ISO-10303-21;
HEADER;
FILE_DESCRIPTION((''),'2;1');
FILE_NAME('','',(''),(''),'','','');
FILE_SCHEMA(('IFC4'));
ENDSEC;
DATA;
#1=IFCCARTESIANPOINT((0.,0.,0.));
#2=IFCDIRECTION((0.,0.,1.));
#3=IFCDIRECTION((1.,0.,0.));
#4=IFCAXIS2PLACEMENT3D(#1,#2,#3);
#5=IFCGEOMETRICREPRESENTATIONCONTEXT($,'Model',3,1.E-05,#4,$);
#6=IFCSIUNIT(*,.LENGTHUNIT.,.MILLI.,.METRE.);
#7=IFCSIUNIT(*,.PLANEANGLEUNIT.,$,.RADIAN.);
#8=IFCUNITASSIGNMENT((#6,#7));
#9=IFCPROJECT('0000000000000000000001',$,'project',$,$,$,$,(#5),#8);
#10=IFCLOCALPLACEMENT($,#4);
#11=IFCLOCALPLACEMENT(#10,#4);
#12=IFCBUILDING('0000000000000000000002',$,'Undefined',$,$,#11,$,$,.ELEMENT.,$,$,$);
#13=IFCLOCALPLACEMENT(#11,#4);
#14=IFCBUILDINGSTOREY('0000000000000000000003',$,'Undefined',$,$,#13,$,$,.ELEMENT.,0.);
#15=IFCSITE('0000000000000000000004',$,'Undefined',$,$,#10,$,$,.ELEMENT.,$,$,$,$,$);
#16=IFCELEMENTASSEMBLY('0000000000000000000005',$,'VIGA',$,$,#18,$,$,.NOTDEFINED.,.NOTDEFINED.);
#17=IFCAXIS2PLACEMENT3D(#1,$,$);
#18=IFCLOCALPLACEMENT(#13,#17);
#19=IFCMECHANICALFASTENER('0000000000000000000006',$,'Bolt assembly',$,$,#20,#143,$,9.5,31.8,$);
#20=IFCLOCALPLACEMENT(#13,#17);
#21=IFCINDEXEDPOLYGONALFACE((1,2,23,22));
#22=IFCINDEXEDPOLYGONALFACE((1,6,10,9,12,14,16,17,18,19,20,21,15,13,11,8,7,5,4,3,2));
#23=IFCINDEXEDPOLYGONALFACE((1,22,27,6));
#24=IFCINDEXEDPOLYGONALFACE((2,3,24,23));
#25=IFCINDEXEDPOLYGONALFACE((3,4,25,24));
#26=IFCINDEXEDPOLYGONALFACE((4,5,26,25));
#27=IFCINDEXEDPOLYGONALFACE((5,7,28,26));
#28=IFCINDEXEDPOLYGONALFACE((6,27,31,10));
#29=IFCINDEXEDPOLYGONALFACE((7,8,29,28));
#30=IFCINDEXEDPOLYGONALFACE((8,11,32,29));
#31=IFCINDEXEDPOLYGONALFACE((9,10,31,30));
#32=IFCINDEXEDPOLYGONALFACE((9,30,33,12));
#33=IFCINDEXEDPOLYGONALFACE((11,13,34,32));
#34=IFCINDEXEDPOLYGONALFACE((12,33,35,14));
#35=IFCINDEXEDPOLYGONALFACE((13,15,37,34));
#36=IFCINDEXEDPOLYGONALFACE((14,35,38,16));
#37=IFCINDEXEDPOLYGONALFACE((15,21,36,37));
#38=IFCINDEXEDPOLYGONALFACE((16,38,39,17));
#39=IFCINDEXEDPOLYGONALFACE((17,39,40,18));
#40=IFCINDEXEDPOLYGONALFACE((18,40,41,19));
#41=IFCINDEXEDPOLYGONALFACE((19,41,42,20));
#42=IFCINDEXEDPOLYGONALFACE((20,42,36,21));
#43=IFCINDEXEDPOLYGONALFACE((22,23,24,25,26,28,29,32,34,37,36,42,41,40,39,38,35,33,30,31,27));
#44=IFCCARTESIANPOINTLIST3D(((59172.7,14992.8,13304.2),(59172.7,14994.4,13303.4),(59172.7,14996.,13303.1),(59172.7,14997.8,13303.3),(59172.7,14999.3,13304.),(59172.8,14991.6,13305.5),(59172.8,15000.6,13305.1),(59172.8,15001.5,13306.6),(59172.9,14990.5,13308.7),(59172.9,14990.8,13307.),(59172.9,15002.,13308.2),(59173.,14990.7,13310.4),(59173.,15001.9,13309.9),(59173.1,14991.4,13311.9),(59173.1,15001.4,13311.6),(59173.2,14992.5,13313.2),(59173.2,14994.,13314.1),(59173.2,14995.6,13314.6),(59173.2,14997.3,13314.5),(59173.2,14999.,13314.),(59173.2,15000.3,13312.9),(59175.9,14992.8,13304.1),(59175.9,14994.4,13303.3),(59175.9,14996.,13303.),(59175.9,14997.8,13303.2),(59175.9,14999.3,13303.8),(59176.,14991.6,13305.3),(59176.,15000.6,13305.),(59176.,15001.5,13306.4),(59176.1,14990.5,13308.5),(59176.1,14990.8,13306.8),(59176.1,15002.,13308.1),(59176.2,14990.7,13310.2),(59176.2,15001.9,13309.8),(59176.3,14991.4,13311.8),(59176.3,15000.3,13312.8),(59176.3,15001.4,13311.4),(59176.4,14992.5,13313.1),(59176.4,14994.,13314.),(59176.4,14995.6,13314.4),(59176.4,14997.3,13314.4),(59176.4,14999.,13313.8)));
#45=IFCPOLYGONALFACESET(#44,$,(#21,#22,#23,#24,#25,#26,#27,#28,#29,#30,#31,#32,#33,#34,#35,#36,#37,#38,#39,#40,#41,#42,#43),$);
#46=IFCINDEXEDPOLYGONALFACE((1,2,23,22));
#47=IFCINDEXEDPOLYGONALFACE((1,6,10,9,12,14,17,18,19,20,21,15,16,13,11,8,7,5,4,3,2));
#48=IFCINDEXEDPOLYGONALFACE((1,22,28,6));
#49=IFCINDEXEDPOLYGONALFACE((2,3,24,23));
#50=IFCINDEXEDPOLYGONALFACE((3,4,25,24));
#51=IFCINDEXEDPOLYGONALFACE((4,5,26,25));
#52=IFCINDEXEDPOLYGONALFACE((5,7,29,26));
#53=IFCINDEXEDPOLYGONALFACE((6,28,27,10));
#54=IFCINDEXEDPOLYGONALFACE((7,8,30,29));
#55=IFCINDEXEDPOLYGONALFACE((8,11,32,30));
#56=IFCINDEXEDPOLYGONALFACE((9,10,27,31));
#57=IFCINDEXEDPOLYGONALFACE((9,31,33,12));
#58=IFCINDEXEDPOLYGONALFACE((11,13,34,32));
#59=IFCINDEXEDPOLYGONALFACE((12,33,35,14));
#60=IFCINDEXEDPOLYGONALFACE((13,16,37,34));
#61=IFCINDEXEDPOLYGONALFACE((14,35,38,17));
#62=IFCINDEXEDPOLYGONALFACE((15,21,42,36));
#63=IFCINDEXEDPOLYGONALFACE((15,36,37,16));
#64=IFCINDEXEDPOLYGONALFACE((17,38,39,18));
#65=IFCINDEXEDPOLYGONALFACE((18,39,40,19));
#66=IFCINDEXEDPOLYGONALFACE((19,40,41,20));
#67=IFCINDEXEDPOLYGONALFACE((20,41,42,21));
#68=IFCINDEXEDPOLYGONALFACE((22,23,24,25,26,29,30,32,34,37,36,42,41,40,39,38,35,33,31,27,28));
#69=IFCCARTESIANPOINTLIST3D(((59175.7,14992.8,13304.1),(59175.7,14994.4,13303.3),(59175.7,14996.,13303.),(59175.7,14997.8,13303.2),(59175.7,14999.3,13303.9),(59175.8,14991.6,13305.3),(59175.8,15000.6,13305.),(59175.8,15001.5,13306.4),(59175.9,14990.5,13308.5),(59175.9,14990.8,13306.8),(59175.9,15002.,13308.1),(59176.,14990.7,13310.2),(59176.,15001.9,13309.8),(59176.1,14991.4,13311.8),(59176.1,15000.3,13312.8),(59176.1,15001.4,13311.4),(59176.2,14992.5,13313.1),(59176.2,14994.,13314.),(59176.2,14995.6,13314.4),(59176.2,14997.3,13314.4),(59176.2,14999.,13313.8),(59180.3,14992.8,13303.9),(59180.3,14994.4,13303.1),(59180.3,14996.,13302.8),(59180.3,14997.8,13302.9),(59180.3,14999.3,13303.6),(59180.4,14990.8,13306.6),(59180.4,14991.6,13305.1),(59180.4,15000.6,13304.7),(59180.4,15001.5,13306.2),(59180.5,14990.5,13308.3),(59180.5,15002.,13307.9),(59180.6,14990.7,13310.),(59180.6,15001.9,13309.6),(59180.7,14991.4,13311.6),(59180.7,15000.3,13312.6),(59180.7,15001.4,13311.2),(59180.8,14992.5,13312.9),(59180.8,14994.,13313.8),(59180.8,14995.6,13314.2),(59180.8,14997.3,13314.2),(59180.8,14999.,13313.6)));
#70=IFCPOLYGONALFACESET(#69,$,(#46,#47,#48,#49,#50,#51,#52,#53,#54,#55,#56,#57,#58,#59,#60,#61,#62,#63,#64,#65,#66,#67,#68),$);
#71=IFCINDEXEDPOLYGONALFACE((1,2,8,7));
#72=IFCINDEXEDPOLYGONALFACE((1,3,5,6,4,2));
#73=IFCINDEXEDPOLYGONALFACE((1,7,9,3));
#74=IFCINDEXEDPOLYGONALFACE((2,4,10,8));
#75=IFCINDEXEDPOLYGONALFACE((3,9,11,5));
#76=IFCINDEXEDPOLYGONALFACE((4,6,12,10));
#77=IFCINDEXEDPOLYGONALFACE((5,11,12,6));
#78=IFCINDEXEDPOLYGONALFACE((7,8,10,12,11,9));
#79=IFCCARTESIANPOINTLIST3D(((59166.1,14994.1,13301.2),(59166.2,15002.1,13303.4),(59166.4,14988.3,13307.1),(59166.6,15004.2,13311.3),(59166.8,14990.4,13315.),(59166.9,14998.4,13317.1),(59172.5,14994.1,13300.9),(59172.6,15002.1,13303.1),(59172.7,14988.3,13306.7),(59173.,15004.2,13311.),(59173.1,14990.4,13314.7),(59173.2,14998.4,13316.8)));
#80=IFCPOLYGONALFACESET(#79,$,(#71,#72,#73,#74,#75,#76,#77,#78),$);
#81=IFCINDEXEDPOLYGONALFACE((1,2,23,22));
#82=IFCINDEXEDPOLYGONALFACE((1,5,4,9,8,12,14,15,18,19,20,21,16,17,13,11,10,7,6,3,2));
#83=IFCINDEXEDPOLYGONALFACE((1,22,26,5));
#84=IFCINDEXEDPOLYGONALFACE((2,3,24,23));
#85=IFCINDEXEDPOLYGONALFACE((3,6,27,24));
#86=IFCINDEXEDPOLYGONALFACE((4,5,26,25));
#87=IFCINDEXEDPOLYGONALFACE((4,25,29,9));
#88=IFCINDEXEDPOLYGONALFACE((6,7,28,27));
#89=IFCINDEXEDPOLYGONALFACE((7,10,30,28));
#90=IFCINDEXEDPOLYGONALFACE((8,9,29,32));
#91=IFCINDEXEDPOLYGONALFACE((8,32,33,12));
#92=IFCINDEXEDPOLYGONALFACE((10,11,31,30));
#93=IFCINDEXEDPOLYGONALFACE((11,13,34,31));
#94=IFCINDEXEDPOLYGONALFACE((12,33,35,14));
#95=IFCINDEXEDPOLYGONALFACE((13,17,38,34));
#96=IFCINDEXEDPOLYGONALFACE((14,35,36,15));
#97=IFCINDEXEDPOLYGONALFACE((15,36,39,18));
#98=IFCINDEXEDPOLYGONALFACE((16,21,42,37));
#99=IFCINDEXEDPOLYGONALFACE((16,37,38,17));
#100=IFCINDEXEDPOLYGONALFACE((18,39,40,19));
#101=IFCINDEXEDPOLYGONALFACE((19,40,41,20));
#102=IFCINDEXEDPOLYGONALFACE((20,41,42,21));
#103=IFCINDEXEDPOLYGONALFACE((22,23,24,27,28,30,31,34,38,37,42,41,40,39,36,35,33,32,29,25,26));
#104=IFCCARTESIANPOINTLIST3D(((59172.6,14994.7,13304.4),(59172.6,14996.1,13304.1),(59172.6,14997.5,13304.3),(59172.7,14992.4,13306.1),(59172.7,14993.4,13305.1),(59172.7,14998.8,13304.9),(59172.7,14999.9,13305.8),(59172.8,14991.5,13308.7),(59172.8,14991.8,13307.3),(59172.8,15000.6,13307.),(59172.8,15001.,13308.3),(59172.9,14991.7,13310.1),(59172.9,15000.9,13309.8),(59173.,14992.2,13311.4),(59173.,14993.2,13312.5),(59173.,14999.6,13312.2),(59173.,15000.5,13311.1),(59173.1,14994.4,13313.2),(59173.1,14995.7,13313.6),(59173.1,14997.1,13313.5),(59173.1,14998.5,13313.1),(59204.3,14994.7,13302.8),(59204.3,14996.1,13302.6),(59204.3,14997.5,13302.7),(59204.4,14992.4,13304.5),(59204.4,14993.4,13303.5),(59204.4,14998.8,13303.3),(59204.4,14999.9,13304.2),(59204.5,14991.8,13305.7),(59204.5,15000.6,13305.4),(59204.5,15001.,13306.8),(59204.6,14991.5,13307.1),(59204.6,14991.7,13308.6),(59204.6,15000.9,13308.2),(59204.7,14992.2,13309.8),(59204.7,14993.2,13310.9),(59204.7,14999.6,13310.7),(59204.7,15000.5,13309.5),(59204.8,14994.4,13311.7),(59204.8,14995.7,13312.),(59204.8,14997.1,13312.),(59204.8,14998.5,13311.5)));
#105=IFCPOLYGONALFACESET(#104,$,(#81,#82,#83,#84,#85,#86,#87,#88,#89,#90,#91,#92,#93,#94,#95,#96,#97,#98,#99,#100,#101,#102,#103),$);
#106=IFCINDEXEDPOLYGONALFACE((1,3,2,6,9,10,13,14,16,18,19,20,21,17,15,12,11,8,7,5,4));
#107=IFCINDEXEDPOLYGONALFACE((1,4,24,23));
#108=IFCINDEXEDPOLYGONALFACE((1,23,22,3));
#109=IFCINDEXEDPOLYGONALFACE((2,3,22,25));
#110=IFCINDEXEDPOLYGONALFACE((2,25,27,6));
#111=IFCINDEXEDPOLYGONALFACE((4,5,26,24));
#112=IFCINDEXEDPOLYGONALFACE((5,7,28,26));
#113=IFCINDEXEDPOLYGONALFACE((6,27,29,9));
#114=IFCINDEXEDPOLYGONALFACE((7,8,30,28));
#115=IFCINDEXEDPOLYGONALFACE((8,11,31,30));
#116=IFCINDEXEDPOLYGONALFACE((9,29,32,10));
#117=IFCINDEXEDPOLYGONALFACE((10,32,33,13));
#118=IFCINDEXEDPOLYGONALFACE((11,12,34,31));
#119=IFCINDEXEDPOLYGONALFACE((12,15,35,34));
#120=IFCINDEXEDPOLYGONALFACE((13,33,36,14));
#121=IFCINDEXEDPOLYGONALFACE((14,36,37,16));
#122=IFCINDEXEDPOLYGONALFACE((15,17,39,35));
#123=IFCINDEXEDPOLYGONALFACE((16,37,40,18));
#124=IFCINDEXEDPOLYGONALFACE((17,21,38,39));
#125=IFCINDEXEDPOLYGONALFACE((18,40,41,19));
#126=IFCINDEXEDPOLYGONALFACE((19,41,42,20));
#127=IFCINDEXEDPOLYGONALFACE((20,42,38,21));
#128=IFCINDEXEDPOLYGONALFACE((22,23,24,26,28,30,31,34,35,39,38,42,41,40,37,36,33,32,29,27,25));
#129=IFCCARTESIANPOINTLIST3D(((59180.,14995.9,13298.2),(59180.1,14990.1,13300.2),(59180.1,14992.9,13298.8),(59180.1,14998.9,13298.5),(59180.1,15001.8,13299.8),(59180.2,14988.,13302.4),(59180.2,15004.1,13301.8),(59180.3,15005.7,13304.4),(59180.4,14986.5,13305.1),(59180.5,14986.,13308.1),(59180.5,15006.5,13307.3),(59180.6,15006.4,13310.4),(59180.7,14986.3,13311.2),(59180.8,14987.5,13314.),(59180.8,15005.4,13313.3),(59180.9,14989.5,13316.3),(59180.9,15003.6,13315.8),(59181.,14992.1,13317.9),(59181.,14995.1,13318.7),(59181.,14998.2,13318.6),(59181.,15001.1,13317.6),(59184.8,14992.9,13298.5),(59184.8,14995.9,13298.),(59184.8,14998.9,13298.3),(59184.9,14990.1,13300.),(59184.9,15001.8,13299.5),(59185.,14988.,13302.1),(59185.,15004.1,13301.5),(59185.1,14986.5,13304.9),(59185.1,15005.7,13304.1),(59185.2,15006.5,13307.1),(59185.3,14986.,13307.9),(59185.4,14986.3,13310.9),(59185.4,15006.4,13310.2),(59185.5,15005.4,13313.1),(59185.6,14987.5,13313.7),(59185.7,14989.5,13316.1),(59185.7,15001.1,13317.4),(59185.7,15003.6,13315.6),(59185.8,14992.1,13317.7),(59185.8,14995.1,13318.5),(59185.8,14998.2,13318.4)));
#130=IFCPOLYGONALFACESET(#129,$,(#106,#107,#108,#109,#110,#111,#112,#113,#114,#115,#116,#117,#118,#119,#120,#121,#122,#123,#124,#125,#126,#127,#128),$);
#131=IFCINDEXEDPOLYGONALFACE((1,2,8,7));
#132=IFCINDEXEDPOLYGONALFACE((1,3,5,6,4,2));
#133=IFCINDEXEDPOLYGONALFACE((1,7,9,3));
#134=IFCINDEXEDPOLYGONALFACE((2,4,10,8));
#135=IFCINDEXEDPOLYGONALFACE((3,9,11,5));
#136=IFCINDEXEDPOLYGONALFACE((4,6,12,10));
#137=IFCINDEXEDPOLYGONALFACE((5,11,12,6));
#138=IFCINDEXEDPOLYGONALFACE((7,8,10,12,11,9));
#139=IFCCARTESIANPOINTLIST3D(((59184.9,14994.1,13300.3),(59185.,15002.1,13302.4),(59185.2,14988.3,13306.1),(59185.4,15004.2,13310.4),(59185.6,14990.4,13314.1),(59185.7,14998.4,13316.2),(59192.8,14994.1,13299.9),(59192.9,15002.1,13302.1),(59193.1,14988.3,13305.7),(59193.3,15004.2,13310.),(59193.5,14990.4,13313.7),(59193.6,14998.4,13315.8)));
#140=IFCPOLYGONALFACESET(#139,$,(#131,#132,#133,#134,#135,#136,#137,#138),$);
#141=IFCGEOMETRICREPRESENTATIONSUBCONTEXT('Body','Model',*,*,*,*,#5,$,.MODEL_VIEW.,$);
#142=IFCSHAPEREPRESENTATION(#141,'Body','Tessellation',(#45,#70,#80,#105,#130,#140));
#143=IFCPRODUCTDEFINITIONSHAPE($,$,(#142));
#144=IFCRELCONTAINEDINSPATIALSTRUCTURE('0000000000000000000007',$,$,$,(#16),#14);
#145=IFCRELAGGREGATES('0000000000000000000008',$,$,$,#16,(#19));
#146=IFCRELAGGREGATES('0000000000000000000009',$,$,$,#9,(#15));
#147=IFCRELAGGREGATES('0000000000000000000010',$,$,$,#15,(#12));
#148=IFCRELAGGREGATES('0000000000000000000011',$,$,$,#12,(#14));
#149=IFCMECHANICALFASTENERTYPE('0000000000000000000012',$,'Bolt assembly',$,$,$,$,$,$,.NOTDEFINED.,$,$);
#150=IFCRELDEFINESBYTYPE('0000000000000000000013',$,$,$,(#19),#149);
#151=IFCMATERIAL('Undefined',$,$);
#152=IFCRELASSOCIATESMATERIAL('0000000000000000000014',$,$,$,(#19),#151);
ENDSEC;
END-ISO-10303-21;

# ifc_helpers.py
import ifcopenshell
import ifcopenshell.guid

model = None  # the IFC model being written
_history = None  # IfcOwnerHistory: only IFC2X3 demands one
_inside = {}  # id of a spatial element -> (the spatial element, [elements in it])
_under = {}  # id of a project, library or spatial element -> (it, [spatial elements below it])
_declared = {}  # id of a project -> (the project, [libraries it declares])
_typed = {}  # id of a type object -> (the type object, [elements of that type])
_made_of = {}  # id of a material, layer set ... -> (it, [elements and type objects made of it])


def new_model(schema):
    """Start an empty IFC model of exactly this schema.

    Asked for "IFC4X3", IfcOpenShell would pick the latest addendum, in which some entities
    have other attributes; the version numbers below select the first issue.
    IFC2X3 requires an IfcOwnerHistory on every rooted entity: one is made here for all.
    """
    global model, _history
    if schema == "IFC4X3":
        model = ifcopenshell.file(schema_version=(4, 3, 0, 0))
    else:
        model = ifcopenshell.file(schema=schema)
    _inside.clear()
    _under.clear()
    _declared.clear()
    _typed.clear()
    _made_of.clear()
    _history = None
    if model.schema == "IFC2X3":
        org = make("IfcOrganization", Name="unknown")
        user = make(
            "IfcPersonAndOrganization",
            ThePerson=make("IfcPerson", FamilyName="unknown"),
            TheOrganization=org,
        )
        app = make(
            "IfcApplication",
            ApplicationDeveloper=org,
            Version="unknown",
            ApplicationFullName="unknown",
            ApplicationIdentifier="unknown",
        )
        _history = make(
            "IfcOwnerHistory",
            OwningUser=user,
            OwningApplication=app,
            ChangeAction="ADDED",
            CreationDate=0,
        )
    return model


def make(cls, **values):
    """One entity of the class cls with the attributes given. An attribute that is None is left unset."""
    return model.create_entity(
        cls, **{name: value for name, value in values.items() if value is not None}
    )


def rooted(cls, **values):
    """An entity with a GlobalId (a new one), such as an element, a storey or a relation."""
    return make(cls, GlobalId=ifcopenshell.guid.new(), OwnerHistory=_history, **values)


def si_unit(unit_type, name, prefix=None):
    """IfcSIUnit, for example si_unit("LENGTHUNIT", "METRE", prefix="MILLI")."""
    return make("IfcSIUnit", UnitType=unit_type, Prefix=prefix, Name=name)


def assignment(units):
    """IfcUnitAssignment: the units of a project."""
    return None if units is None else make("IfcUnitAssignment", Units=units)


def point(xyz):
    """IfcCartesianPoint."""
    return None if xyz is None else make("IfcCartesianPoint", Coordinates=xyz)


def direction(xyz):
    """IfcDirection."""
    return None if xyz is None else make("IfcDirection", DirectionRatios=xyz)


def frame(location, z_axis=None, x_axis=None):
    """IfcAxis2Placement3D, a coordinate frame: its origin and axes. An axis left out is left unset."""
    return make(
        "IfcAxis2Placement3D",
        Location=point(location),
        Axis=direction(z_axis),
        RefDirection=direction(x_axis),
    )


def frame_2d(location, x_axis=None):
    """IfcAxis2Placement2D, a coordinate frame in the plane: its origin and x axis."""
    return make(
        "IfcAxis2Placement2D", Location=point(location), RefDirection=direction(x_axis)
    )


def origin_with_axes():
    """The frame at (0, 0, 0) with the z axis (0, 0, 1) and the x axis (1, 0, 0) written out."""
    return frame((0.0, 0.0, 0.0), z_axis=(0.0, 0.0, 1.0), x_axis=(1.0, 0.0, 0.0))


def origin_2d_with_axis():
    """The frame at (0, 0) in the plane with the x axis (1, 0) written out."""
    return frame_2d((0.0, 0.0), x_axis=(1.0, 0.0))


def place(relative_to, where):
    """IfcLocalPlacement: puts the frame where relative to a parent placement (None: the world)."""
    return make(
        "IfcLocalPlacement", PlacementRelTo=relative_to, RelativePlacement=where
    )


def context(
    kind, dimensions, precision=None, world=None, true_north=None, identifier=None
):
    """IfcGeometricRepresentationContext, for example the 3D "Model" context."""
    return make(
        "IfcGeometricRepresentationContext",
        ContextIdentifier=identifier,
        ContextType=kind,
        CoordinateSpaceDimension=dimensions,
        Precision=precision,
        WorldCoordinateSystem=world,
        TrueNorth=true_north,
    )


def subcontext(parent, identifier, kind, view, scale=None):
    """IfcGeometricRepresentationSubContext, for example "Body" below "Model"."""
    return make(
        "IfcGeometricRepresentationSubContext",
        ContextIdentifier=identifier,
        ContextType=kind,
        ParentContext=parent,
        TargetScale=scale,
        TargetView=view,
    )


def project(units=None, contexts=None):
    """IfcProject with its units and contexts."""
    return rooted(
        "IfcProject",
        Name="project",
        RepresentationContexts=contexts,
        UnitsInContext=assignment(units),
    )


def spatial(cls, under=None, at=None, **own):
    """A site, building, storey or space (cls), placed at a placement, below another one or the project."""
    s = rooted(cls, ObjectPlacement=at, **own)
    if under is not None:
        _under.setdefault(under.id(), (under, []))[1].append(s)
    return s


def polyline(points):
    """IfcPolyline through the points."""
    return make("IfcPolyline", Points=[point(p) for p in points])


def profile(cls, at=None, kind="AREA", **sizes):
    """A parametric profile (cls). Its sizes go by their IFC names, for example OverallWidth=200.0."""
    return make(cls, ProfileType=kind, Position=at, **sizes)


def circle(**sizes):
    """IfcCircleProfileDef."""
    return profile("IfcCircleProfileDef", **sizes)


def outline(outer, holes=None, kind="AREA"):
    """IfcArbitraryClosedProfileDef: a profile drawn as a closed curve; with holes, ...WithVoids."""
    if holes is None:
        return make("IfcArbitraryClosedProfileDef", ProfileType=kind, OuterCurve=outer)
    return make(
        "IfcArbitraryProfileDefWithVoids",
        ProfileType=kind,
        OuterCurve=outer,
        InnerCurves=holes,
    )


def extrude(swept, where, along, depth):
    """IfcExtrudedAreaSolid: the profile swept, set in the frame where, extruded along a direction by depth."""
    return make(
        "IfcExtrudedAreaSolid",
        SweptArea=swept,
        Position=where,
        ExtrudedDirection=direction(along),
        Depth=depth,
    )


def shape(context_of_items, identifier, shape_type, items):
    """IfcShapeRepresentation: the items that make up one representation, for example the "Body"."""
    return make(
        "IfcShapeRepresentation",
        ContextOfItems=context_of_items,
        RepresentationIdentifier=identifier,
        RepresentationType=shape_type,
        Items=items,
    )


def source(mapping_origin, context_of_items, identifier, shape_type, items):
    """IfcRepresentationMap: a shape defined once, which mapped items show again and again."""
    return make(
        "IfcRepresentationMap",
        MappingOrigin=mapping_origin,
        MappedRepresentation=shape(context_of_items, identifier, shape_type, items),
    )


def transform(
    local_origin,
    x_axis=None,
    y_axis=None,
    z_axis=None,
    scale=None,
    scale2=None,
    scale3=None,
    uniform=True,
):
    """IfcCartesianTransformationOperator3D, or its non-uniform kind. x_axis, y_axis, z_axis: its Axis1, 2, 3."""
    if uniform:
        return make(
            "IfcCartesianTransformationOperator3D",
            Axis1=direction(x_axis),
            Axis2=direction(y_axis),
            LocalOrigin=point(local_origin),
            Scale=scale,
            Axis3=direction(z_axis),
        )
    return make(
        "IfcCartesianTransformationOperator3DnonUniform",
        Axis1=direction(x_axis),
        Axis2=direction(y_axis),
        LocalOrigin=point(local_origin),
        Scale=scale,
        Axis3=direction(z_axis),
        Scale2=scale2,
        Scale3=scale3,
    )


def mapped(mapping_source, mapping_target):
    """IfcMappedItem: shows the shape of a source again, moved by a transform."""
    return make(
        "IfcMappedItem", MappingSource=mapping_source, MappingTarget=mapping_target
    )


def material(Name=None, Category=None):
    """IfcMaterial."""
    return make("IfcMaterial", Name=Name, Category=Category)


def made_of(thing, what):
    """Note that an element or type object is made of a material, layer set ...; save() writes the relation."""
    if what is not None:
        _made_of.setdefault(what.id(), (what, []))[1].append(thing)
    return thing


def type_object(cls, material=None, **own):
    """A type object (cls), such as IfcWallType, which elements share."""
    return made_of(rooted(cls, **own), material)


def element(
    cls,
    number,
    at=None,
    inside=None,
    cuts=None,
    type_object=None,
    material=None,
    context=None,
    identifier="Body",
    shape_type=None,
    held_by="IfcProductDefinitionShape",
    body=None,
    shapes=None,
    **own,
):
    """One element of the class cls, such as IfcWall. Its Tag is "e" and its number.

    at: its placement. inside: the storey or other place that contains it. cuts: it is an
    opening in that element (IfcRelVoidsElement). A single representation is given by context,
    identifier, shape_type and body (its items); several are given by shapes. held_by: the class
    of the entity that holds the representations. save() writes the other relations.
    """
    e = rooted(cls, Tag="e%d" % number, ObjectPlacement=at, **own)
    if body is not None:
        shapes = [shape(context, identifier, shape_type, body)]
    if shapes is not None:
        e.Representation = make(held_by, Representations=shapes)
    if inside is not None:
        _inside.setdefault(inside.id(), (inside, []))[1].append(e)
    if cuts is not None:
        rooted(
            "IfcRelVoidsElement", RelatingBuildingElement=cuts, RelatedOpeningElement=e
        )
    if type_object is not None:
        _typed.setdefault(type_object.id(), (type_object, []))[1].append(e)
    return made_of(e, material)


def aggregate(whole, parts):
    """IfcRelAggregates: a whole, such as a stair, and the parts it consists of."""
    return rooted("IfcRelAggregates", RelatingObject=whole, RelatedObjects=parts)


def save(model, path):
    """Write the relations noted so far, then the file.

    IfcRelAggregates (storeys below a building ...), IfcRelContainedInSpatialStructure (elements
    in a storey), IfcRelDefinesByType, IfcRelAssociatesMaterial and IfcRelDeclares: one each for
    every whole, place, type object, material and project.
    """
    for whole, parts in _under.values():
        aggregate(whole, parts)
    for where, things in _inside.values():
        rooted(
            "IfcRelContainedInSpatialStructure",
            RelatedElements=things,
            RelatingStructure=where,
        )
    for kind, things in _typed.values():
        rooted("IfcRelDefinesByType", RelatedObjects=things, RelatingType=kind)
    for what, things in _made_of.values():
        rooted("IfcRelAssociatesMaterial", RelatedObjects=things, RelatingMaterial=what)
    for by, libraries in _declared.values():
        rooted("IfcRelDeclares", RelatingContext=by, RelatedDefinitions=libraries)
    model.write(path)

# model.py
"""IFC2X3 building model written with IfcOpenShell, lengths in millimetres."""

from ifc_helpers import new_model, si_unit, frame, origin_with_axes, origin_2d_with_axis, place, context, subcontext, project, spatial, polyline, circle, outline, extrude, source, transform, mapped, material, type_object, element, aggregate, save


model = new_model("IFC2X3")

# Units and contexts
model_context = context("Model", 3, precision=1e-05, world=origin_with_axes())
body_context = subcontext(model_context, "Body", "Model", "MODEL_VIEW")
ifc_project = project(units=[si_unit("LENGTHUNIT", "METRE", prefix="MILLI"), si_unit("PLANEANGLEUNIT", "RADIAN")], contexts=[model_context])

# Site, building, storey
site_placement = place(None, origin_with_axes())
site = spatial("IfcSite", under=ifc_project, at=site_placement, Name="Undefined", CompositionType="ELEMENT")
building_placement = place(site_placement, origin_with_axes())
building = spatial("IfcBuilding", under=site, at=building_placement, Name="Undefined", CompositionType="ELEMENT")
storey_placement = place(building_placement, origin_with_axes())
storey = spatial("IfcBuildingStorey", under=building, at=storey_placement, Name="Undefined", CompositionType="ELEMENT", Elevation=0.0)

# Element assembly
assembly_1_placement = place(storey_placement, origin_with_axes())
assembly_1 = element("IfcElementAssembly", 1, at=assembly_1_placement, inside=storey, Name="VIGA", AssemblyPlace="NOTDEFINED", PredefinedType="NOTDEFINED")

# Shared definitions
mechanical_fastener_type = type_object("IfcMechanicalFastenerType", Name="Bolt assembly")

# Shared definitions
ifc_material_1 = material(Name="Undefined")

# Mechanical fastener
shared_shape_1 = source(origin_with_axes(), body_context, "Body", "SweptSolid", [
    extrude(circle(Radius=5.8, at=origin_2d_with_axis()), frame((0.0, -3.1, 0.0), z_axis=(0.0, 1.0, 0.0), x_axis=(1.0, 0.0, 0.0)), (0.0, 0.0, 1.0), 3.2),
    extrude(circle(Radius=5.8, at=origin_2d_with_axis()), frame((0.0, -0.1, 0.0), z_axis=(0.0, 1.0, 0.0), x_axis=(1.0, 0.0, 0.0)), (0.0, 0.0, 1.0), 4.6),
    extrude(outline(polyline([(7.1, -4.1), (7.1, 4.1), (0.0, 8.2), (-7.1, 4.1), (-7.1, -4.1), (0.0, -8.2), (7.1, -4.1)])), frame((0.0, -9.5, 0.0), z_axis=(0.0, 1.0, 0.0), x_axis=(1.0, 0.0, 0.0)), (0.0, 0.0, 1.0), 6.3),
    extrude(circle(Radius=4.8, at=origin_2d_with_axis()), frame((0.0, -3.2, 0.0), z_axis=(0.0, 1.0, 0.0), x_axis=(1.0, 0.0, 0.0)), (0.0, 0.0, 1.0), 31.8),
    extrude(circle(Radius=10.3, at=origin_2d_with_axis()), frame((0.0, 4.5, 0.0), z_axis=(0.0, 1.0, 0.0), x_axis=(1.0, 0.0, 0.0)), (0.0, 0.0, 1.0), 4.8),
    extrude(outline(polyline([(7.1, -4.1), (7.1, 4.1), (0.0, 8.2), (-7.1, 4.1), (-7.1, -4.1), (0.0, -8.2), (7.1, -4.1)])), frame((0.0, 9.3, 0.0), z_axis=(0.0, 1.0, 0.0), x_axis=(1.0, 0.0, 0.0)), (0.0, 0.0, 1.0), 7.9),
])
mechanical_fastener_1_placement = place(assembly_1_placement, frame((59176.0, 14996.3, 13308.7), z_axis=(-0.034712, 0.707107, -0.706254), x_axis=(0.034712, 0.707107, 0.706254)))
mechanical_fastener_1 = element("IfcMechanicalFastener", 2, at=mechanical_fastener_1_placement, type_object=mechanical_fastener_type, material=ifc_material_1, Name="Bolt assembly", NominalDiameter=9.5, NominalLength=31.8, context=body_context, shape_type="MappedRepresentation", body=[
    mapped(shared_shape_1, transform((0.0, 0.0, 0.0))),
])
aggregate(assembly_1, [mechanical_fastener_1])

save(model, "model.ifc")
